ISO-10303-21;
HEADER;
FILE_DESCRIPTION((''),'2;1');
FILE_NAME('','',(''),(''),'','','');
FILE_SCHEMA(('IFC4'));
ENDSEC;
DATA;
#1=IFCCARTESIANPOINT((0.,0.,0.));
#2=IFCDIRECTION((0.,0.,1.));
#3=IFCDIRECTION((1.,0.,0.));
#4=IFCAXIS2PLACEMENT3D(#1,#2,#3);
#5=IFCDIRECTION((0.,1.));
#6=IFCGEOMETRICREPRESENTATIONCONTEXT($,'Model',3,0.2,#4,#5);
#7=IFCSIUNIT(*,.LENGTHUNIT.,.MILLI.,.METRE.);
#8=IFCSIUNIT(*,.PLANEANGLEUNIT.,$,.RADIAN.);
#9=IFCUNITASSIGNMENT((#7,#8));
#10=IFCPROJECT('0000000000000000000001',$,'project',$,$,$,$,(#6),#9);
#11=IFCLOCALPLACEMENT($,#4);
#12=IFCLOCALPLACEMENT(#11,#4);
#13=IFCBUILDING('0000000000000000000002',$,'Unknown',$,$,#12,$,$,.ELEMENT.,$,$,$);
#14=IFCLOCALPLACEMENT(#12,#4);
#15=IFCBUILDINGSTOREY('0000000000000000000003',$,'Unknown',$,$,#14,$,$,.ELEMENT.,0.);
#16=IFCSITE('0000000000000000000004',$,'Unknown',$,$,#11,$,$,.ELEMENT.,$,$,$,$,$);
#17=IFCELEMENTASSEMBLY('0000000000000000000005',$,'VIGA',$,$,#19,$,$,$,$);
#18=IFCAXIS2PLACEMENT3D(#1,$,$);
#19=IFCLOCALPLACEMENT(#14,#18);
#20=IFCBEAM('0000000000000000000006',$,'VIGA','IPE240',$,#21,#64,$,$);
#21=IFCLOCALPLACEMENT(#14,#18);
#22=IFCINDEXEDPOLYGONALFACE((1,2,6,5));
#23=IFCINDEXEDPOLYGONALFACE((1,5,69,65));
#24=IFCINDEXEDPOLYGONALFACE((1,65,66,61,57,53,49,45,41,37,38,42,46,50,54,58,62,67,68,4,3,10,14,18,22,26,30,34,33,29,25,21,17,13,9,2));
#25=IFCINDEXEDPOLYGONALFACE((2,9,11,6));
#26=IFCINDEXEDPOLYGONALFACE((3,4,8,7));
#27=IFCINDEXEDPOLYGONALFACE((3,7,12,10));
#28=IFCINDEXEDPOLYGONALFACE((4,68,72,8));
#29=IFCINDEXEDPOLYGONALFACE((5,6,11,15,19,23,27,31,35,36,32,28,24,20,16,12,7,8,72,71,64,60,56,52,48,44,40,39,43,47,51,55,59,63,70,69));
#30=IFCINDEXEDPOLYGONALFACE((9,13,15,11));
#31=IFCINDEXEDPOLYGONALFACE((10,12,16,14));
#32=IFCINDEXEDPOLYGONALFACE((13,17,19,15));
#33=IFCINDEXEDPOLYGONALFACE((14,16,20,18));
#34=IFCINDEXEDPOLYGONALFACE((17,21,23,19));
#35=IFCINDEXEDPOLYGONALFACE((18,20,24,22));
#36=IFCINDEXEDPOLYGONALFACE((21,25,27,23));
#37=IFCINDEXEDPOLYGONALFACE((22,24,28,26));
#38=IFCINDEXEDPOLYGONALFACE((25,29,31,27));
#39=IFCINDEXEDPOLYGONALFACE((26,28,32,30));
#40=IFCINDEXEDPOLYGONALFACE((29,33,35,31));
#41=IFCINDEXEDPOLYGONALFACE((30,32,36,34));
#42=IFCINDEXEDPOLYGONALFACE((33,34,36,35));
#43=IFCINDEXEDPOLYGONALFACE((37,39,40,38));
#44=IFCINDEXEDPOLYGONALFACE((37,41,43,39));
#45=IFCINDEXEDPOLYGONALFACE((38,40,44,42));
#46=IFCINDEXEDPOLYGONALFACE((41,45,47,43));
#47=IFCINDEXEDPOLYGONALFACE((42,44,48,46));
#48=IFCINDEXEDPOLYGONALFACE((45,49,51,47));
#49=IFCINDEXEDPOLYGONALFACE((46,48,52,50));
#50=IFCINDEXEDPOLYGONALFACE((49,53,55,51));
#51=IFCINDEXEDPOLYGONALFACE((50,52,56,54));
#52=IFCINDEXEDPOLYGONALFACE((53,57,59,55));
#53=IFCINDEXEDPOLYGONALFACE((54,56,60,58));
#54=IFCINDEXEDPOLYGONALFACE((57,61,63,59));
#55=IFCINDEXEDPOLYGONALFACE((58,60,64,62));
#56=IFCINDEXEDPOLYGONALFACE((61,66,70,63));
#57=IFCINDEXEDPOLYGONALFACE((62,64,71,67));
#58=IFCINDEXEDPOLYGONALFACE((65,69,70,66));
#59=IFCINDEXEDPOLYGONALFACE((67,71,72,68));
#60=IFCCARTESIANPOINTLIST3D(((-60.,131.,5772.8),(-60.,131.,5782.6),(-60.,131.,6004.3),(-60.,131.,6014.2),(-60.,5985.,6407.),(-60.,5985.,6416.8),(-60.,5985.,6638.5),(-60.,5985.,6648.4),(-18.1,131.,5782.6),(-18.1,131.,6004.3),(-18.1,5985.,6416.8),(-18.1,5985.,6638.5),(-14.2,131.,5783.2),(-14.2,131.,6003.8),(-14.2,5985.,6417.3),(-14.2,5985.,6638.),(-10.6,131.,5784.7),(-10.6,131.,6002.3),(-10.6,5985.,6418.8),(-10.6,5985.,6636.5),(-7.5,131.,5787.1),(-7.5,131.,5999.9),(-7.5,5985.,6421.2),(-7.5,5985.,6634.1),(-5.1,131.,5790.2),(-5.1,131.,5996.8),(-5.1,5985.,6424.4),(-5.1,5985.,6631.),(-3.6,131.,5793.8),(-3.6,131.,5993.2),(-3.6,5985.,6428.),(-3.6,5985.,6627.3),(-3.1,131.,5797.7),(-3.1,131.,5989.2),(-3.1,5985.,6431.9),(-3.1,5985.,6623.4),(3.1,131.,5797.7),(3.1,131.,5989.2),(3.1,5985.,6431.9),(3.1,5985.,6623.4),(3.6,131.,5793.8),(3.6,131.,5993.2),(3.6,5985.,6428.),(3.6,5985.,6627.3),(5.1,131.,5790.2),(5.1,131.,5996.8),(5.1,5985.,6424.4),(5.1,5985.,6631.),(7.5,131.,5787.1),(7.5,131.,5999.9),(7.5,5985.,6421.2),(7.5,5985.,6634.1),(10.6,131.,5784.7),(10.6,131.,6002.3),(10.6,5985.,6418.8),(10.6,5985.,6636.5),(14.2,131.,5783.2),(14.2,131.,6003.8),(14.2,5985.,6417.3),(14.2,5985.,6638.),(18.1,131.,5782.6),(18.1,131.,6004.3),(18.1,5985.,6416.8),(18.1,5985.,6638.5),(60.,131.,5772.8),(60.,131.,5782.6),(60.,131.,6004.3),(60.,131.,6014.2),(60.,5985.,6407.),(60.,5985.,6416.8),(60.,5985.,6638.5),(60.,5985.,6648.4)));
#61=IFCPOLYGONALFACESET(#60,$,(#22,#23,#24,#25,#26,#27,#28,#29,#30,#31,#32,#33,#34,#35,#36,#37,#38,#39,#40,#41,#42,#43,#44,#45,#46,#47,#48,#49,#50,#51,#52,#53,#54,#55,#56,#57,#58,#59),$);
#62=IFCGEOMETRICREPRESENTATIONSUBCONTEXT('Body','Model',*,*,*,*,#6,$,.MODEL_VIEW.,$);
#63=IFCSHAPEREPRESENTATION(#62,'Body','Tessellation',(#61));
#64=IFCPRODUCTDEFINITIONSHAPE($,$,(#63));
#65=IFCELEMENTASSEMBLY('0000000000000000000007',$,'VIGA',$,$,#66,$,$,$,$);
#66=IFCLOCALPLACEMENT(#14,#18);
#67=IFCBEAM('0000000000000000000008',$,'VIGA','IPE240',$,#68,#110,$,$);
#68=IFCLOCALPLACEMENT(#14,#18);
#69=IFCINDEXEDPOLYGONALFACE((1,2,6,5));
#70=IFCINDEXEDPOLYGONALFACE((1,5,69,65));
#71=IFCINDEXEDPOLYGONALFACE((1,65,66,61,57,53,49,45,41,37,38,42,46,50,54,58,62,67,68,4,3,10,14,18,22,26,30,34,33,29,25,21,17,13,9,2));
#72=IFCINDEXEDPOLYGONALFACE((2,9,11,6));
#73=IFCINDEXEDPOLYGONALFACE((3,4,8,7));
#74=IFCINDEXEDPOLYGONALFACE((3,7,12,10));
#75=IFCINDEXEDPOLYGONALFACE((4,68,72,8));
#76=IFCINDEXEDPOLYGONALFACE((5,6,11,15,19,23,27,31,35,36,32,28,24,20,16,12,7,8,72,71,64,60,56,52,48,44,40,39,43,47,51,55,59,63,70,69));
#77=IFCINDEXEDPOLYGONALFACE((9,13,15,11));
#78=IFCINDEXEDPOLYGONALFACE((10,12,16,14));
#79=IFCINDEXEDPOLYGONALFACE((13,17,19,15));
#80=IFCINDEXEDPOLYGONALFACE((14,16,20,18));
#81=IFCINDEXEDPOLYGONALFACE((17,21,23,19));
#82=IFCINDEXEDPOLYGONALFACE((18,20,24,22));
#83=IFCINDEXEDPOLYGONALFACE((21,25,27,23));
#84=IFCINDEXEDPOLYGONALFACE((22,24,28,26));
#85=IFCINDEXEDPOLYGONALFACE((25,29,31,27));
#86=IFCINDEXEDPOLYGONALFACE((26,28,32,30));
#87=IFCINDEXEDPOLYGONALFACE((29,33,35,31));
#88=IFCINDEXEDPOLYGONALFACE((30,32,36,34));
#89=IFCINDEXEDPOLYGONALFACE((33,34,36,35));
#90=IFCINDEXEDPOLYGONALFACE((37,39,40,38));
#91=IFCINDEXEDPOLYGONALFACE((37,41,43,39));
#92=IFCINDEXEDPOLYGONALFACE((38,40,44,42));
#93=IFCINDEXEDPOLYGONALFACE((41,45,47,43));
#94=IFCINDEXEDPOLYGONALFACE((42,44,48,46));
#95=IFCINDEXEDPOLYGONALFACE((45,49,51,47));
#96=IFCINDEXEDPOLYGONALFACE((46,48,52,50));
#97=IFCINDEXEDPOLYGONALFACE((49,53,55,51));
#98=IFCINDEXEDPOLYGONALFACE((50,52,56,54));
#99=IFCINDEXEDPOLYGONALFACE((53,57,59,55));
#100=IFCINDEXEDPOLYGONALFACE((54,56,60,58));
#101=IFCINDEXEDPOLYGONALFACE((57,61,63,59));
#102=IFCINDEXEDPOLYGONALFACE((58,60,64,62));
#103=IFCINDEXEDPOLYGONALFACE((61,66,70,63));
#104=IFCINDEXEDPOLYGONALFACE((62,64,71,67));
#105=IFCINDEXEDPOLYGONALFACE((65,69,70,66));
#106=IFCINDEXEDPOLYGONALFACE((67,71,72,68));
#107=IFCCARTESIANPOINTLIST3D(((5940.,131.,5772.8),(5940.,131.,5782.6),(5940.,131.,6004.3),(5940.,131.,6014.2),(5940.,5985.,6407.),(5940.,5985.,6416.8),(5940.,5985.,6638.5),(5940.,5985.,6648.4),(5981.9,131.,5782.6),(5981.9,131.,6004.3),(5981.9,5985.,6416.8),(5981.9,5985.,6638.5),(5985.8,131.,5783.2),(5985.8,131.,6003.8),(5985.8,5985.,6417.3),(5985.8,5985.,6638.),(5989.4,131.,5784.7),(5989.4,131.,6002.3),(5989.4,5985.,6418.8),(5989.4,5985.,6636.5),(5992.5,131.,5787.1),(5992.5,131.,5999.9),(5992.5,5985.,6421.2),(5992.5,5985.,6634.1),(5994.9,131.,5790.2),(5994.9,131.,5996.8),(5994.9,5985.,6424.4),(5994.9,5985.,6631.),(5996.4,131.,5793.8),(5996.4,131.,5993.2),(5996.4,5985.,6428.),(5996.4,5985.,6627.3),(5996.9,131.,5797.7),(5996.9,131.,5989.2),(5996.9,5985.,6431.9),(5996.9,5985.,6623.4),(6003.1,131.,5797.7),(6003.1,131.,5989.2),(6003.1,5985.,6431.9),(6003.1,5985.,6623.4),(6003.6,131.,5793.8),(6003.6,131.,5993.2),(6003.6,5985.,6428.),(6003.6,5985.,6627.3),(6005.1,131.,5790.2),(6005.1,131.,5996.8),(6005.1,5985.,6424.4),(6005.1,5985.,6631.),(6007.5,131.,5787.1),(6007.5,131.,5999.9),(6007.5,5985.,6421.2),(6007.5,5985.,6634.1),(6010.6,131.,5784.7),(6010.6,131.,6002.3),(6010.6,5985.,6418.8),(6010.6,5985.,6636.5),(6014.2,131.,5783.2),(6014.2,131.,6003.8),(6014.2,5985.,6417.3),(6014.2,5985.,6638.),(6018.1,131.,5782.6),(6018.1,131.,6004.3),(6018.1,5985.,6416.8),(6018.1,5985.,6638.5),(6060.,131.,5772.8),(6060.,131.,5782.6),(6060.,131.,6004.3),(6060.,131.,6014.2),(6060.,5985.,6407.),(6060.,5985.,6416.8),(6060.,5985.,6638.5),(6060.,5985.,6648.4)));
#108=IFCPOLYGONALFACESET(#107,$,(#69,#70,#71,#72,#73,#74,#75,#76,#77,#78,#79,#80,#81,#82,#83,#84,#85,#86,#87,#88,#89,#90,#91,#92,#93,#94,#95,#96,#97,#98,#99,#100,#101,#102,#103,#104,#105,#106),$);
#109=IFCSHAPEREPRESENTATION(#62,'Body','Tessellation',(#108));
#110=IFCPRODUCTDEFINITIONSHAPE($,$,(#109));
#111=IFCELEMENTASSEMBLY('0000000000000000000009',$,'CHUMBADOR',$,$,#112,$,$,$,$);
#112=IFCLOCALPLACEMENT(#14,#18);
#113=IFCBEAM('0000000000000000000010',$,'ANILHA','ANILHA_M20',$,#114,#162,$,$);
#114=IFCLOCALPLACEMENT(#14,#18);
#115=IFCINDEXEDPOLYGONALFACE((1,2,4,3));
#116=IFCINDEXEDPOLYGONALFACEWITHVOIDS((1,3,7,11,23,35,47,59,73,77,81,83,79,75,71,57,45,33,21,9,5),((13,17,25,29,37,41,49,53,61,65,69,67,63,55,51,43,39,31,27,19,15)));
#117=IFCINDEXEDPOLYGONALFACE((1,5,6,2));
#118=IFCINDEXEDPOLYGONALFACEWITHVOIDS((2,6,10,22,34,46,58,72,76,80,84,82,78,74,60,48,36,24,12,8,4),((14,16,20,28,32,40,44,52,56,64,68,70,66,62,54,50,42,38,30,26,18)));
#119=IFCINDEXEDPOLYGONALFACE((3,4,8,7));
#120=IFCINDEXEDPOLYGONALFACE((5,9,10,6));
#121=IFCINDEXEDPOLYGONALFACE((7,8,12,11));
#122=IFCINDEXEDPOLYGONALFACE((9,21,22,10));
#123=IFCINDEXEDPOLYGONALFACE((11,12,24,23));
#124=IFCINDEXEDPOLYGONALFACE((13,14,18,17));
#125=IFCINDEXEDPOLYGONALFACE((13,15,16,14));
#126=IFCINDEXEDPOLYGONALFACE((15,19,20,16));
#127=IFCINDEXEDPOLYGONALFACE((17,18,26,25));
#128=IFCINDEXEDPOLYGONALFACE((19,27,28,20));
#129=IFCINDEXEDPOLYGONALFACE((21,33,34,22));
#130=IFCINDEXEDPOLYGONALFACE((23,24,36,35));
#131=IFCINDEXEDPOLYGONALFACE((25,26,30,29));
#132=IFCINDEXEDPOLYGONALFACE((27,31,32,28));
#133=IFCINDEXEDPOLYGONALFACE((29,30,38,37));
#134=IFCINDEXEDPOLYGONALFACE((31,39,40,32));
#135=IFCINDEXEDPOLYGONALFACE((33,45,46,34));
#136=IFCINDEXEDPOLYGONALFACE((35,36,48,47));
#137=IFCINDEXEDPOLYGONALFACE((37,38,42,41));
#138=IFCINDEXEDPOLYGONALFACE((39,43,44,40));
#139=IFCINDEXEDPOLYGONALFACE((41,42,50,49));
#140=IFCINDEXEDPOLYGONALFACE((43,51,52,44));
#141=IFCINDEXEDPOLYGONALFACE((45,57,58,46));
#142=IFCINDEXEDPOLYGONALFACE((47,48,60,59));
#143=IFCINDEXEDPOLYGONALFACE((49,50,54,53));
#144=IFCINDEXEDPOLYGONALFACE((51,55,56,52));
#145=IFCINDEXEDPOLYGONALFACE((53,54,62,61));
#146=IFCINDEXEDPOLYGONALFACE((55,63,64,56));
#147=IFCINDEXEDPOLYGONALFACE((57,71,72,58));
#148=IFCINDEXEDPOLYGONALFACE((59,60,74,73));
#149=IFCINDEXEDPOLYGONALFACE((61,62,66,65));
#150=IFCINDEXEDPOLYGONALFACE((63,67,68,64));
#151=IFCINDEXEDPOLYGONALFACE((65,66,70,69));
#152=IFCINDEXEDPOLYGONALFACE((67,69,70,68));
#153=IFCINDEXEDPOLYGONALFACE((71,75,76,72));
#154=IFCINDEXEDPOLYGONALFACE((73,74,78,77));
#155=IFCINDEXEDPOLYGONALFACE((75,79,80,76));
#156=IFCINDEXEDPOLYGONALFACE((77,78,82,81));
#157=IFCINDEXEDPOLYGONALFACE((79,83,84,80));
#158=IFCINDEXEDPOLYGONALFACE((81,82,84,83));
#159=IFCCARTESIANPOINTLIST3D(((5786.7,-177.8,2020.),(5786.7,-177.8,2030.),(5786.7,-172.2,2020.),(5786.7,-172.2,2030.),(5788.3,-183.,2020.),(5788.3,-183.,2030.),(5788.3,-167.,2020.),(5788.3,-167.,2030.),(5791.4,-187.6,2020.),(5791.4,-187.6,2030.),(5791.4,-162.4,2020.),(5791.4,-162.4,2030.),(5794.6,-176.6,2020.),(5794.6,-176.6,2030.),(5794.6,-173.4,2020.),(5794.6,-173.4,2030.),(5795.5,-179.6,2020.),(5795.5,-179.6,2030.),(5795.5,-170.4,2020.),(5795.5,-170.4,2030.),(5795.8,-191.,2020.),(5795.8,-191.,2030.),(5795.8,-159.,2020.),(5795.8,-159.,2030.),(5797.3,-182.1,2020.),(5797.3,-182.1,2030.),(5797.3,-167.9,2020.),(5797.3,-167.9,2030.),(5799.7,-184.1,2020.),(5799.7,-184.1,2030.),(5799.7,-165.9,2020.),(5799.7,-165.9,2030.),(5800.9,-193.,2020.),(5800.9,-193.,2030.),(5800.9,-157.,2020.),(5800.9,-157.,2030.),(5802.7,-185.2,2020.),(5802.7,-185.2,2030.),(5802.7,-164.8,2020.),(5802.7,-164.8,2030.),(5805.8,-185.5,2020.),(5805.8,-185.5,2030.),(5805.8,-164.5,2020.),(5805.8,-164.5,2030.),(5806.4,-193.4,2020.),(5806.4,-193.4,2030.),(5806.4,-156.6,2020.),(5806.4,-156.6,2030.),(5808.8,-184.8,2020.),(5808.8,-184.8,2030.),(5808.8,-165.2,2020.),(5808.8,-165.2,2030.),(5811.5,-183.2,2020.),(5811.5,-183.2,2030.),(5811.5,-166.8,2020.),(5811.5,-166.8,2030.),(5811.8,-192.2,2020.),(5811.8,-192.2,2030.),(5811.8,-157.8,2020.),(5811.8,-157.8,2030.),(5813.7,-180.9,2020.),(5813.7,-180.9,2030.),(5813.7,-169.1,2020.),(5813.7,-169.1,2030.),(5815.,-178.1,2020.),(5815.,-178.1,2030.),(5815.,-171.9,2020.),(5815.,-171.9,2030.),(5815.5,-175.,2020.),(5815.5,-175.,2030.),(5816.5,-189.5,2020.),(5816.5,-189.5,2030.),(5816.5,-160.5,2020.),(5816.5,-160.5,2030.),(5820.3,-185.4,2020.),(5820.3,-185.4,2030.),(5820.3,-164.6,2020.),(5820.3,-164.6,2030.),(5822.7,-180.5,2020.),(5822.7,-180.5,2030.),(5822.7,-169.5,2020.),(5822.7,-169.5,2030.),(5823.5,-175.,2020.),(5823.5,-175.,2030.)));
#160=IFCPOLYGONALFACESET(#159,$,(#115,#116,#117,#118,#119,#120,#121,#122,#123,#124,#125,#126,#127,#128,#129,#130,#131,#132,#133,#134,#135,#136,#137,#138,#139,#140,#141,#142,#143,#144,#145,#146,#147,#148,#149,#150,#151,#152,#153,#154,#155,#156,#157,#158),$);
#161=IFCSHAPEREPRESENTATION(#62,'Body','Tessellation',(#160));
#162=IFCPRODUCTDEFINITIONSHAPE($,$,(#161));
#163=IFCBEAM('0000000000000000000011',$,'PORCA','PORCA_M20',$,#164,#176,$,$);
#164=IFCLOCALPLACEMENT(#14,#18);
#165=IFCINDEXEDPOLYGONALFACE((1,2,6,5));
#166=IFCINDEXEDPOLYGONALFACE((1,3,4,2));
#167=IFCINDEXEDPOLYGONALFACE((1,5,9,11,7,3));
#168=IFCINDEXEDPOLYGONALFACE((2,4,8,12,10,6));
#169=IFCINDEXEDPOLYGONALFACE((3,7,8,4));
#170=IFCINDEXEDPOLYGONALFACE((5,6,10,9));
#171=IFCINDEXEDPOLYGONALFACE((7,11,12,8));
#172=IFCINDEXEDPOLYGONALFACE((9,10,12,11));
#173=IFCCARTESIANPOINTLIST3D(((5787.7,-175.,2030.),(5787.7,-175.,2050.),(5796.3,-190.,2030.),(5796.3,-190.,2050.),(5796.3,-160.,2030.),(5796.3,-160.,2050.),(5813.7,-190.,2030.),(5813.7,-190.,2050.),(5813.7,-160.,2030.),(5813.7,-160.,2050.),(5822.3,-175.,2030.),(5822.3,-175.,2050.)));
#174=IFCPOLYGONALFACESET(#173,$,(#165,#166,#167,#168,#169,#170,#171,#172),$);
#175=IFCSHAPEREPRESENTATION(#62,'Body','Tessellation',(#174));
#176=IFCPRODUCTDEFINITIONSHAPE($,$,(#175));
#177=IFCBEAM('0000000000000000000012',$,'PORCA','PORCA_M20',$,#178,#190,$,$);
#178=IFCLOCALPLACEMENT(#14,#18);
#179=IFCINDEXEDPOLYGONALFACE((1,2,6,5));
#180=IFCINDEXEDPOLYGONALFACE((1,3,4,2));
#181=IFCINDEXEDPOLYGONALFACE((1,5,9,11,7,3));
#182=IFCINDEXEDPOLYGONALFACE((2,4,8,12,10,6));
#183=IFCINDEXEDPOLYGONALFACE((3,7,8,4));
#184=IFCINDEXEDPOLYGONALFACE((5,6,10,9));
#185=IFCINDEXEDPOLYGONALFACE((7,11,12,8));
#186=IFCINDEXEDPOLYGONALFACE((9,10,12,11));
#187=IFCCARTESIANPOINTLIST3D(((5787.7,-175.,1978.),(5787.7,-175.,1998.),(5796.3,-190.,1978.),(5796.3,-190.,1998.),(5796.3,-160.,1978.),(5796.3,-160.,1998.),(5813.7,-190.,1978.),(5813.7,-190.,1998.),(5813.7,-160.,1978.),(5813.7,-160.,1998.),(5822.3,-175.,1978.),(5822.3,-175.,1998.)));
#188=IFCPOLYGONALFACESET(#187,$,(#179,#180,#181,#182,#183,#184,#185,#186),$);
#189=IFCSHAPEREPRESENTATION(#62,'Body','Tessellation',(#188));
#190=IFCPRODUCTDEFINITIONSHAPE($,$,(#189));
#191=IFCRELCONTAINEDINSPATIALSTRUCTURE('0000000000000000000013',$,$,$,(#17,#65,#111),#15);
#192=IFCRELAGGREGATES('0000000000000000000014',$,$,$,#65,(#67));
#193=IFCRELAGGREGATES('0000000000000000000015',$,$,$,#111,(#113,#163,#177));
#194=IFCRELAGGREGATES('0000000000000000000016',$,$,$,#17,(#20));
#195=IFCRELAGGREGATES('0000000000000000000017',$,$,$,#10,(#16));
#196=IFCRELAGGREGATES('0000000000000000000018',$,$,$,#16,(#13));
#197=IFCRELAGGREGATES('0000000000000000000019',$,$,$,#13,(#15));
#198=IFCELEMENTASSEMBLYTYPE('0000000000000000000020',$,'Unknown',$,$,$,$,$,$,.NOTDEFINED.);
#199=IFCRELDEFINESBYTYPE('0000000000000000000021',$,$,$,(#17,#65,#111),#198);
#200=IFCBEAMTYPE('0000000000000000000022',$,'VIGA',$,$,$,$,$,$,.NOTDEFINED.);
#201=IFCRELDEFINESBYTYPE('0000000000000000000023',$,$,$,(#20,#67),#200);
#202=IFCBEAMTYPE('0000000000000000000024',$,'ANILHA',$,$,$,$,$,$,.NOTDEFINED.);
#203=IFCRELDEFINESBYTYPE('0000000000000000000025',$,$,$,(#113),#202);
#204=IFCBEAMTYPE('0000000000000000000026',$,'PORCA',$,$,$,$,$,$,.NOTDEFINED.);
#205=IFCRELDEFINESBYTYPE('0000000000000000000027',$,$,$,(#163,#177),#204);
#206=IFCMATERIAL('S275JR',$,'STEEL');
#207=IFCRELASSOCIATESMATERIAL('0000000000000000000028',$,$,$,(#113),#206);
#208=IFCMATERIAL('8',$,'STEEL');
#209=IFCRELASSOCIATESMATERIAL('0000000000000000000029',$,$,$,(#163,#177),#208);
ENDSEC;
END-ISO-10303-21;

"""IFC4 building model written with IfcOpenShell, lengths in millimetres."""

from ifc_helpers import new_model, si_unit, direction, frame, origin_with_axes, origin_2d_with_axis, place, context, subcontext, project, spatial, polyline, hollow_circle, i_section, outline, extrude, clip, halfspace, material, material_profile, profile_set, profile_usage, type_object, element, aggregate, save


model = new_model("IFC4")

# Units and contexts
model_context = context("Model", 3, precision=0.2, world=origin_with_axes(), true_north=direction((0.0, 1.0)))
body_context = subcontext(model_context, "Body", "Model", "MODEL_VIEW")
ifc_project = project(units=[si_unit("LENGTHUNIT", "METRE", prefix="MILLI"), si_unit("PLANEANGLEUNIT", "RADIAN")], contexts=[model_context])

# Site, building, storey
site_placement = place(None, origin_with_axes())
site = spatial("IfcSite", under=ifc_project, at=site_placement, Name="Unknown", CompositionType="ELEMENT")
building_placement = place(site_placement, origin_with_axes())
building = spatial("IfcBuilding", under=site, at=building_placement, Name="Unknown", CompositionType="ELEMENT")
storey_placement = place(building_placement, origin_with_axes())
storey = spatial("IfcBuildingStorey", under=building, at=storey_placement, Name="Unknown", CompositionType="ELEMENT", Elevation=0.0)

# Shared definitions
element_assembly_type = type_object("IfcElementAssemblyType", Name="Unknown", PredefinedType="NOTDEFINED")

# Shared definitions
ifc_material_1 = material(Name="8", Category="STEEL")
ifc_material_profile_1 = material_profile(ifc_material_1, outline(polyline([(8.7, -15.0), (17.3, 0.0), (8.7, 15.0), (-8.7, 15.0), (-17.3, 0.0), (-8.7, -15.0), (8.7, -15.0)])), Name="PORCA_M20")
ifc_profile_set_1 = profile_set([ifc_material_profile_1])
ifc_profile_usage_1 = profile_usage(ifc_profile_set_1, cardinal=5)
ifc_material_2 = material(Name="S275JR", Category="STEEL")
ifc_material_profile_2 = material_profile(ifc_material_2, hollow_circle(Radius=18.5, WallThickness=8.0, at=origin_2d_with_axis()), Name="ANILHA_M20")
ifc_profile_set_2 = profile_set([ifc_material_profile_2])
ifc_profile_usage_2 = profile_usage(ifc_profile_set_2, cardinal=5)

# Element assembly, beam
assembly_1_placement = place(storey_placement, frame((0.0, 12.9, 5880.7), z_axis=(1.0, 0.0, 0.0), x_axis=(0.0, 0.994183, 0.107703)))
assembly_1 = element("IfcElementAssembly", 1, at=assembly_1_placement, inside=storey, type_object=element_assembly_type, Name="VIGA")
beam_type_1 = type_object("IfcBeamType", Name="VIGA", PredefinedType="NOTDEFINED")
beam_1_placement = place(assembly_1_placement, origin_with_axes())
beam_1 = element("IfcBeam", 2, at=beam_1_placement, type_object=beam_type_1, Name="VIGA", Description="IPE240", context=body_context, shape_type="Clipping", body=[
    clip(clip(extrude(i_section(OverallWidth=120.0, OverallDepth=240.0, WebThickness=6.2, FlangeThickness=9.8, FilletRadius=15.0, FlangeEdgeRadius=0.0, FlangeSlope=0.0, at=origin_2d_with_axis()), frame((-121.2, 0.0, 0.0), z_axis=(-1.0, 0.0, 0.0), x_axis=(0.0, 0.0, 1.0)), (0.0, 0.0, -1.0), 6368.3), halfspace(frame((105.8, -120.0, 0.0), z_axis=(0.994183, -0.107703, 0.0), x_axis=(0.107703, 0.994183, 0.0)), True)), halfspace(frame((6021.8, 136.5, 0.0), z_axis=(0.994183, -0.107703, 0.0), x_axis=(-0.107703, -0.994183, 0.0)), False)),
])

# Element assembly, beam
assembly_2_placement = place(storey_placement, frame((6000.0, 12.9, 5880.7), z_axis=(1.0, 0.0, 0.0), x_axis=(0.0, 0.994183, 0.107703)))
assembly_2 = element("IfcElementAssembly", 3, at=assembly_2_placement, inside=storey, type_object=element_assembly_type, Name="VIGA")
beam_2_placement = place(assembly_2_placement, origin_with_axes())
beam_2 = element("IfcBeam", 4, at=beam_2_placement, type_object=beam_type_1, Name="VIGA", Description="IPE240", context=body_context, shape_type="Clipping", body=[
    clip(clip(extrude(i_section(OverallWidth=120.0, OverallDepth=240.0, WebThickness=6.2, FlangeThickness=9.8, FilletRadius=15.0, FlangeEdgeRadius=0.0, FlangeSlope=0.0, at=origin_2d_with_axis()), frame((-121.2, 0.0, 0.0), z_axis=(-1.0, 0.0, 0.0), x_axis=(0.0, 0.0, 1.0)), (0.0, 0.0, -1.0), 6368.3), halfspace(frame((6021.8, 136.5, 0.0), z_axis=(0.994183, -0.107703, 0.0), x_axis=(-0.107703, -0.994183, 0.0)), False)), halfspace(frame((105.8, -120.0, 0.0), z_axis=(0.994183, -0.107703, 0.0), x_axis=(0.107703, 0.994183, 0.0)), True)),
])
aggregate(assembly_2, [beam_2])

# Element assembly, beams
assembly_3_placement = place(storey_placement, frame((5805.0, -175.0, 1945.0), z_axis=(1.0, 0.0, 0.0), x_axis=(0.0, 0.0, -1.0)))
assembly_3 = element("IfcElementAssembly", 5, at=assembly_3_placement, inside=storey, type_object=element_assembly_type, Name="CHUMBADOR")
beam_type_2 = type_object("IfcBeamType", Name="ANILHA", PredefinedType="NOTDEFINED")
beam_3_placement = place(assembly_3_placement, frame((-85.0, 0.0, 0.0), z_axis=(0.0, 0.0, 1.0), x_axis=(1.0, 0.0, 0.0)))
beam_3 = element("IfcBeam", 6, at=beam_3_placement, type_object=beam_type_2, material=ifc_profile_usage_2, Name="ANILHA", Description="ANILHA_M20", context=body_context, shape_type="SolidModel", body=[
    extrude(hollow_circle(Radius=18.5, WallThickness=8.0, at=origin_2d_with_axis()), frame((0.0, 0.0, 0.0), z_axis=(-1.0, 0.0, 0.0), x_axis=(0.0, 0.0, 1.0)), (0.0, 0.0, -1.0), 10.0),
])
beam_type_3 = type_object("IfcBeamType", Name="PORCA", PredefinedType="NOTDEFINED")
beam_4_placement = place(assembly_3_placement, frame((-105.0, 0.0, 0.0), z_axis=(0.0, 0.0, -1.0), x_axis=(1.0, 0.0, 0.0)))
beam_4 = element("IfcBeam", 7, at=beam_4_placement, type_object=beam_type_3, material=ifc_profile_usage_1, Name="PORCA", Description="PORCA_M20", context=body_context, shape_type="SolidModel", body=[
    extrude(outline(polyline([(8.7, -15.0), (17.3, 0.0), (8.7, 15.0), (-8.7, 15.0), (-17.3, 0.0), (-8.7, -15.0), (8.7, -15.0)])), frame((0.0, 0.0, 0.0), z_axis=(-1.0, 0.0, 0.0), x_axis=(0.0, 0.0, 1.0)), (0.0, 0.0, -1.0), 20.0),
])
beam_5_placement = place(assembly_3_placement, frame((-53.0, 0.0, 0.0), z_axis=(0.0, 0.0, -1.0), x_axis=(1.0, 0.0, 0.0)))
beam_5 = element("IfcBeam", 8, at=beam_5_placement, type_object=beam_type_3, material=ifc_profile_usage_1, Name="PORCA", Description="PORCA_M20", context=body_context, shape_type="SolidModel", body=[
    extrude(outline(polyline([(8.7, -15.0), (17.3, 0.0), (8.7, 15.0), (-8.7, 15.0), (-17.3, 0.0), (-8.7, -15.0), (8.7, -15.0)])), frame((0.0, 0.0, 0.0), z_axis=(-1.0, 0.0, 0.0), x_axis=(0.0, 0.0, 1.0)), (0.0, 0.0, -1.0), 20.0),
])
aggregate(assembly_3, [beam_3, beam_4, beam_5])

aggregate(assembly_1, [beam_1])

save(model, "model.ifc")
